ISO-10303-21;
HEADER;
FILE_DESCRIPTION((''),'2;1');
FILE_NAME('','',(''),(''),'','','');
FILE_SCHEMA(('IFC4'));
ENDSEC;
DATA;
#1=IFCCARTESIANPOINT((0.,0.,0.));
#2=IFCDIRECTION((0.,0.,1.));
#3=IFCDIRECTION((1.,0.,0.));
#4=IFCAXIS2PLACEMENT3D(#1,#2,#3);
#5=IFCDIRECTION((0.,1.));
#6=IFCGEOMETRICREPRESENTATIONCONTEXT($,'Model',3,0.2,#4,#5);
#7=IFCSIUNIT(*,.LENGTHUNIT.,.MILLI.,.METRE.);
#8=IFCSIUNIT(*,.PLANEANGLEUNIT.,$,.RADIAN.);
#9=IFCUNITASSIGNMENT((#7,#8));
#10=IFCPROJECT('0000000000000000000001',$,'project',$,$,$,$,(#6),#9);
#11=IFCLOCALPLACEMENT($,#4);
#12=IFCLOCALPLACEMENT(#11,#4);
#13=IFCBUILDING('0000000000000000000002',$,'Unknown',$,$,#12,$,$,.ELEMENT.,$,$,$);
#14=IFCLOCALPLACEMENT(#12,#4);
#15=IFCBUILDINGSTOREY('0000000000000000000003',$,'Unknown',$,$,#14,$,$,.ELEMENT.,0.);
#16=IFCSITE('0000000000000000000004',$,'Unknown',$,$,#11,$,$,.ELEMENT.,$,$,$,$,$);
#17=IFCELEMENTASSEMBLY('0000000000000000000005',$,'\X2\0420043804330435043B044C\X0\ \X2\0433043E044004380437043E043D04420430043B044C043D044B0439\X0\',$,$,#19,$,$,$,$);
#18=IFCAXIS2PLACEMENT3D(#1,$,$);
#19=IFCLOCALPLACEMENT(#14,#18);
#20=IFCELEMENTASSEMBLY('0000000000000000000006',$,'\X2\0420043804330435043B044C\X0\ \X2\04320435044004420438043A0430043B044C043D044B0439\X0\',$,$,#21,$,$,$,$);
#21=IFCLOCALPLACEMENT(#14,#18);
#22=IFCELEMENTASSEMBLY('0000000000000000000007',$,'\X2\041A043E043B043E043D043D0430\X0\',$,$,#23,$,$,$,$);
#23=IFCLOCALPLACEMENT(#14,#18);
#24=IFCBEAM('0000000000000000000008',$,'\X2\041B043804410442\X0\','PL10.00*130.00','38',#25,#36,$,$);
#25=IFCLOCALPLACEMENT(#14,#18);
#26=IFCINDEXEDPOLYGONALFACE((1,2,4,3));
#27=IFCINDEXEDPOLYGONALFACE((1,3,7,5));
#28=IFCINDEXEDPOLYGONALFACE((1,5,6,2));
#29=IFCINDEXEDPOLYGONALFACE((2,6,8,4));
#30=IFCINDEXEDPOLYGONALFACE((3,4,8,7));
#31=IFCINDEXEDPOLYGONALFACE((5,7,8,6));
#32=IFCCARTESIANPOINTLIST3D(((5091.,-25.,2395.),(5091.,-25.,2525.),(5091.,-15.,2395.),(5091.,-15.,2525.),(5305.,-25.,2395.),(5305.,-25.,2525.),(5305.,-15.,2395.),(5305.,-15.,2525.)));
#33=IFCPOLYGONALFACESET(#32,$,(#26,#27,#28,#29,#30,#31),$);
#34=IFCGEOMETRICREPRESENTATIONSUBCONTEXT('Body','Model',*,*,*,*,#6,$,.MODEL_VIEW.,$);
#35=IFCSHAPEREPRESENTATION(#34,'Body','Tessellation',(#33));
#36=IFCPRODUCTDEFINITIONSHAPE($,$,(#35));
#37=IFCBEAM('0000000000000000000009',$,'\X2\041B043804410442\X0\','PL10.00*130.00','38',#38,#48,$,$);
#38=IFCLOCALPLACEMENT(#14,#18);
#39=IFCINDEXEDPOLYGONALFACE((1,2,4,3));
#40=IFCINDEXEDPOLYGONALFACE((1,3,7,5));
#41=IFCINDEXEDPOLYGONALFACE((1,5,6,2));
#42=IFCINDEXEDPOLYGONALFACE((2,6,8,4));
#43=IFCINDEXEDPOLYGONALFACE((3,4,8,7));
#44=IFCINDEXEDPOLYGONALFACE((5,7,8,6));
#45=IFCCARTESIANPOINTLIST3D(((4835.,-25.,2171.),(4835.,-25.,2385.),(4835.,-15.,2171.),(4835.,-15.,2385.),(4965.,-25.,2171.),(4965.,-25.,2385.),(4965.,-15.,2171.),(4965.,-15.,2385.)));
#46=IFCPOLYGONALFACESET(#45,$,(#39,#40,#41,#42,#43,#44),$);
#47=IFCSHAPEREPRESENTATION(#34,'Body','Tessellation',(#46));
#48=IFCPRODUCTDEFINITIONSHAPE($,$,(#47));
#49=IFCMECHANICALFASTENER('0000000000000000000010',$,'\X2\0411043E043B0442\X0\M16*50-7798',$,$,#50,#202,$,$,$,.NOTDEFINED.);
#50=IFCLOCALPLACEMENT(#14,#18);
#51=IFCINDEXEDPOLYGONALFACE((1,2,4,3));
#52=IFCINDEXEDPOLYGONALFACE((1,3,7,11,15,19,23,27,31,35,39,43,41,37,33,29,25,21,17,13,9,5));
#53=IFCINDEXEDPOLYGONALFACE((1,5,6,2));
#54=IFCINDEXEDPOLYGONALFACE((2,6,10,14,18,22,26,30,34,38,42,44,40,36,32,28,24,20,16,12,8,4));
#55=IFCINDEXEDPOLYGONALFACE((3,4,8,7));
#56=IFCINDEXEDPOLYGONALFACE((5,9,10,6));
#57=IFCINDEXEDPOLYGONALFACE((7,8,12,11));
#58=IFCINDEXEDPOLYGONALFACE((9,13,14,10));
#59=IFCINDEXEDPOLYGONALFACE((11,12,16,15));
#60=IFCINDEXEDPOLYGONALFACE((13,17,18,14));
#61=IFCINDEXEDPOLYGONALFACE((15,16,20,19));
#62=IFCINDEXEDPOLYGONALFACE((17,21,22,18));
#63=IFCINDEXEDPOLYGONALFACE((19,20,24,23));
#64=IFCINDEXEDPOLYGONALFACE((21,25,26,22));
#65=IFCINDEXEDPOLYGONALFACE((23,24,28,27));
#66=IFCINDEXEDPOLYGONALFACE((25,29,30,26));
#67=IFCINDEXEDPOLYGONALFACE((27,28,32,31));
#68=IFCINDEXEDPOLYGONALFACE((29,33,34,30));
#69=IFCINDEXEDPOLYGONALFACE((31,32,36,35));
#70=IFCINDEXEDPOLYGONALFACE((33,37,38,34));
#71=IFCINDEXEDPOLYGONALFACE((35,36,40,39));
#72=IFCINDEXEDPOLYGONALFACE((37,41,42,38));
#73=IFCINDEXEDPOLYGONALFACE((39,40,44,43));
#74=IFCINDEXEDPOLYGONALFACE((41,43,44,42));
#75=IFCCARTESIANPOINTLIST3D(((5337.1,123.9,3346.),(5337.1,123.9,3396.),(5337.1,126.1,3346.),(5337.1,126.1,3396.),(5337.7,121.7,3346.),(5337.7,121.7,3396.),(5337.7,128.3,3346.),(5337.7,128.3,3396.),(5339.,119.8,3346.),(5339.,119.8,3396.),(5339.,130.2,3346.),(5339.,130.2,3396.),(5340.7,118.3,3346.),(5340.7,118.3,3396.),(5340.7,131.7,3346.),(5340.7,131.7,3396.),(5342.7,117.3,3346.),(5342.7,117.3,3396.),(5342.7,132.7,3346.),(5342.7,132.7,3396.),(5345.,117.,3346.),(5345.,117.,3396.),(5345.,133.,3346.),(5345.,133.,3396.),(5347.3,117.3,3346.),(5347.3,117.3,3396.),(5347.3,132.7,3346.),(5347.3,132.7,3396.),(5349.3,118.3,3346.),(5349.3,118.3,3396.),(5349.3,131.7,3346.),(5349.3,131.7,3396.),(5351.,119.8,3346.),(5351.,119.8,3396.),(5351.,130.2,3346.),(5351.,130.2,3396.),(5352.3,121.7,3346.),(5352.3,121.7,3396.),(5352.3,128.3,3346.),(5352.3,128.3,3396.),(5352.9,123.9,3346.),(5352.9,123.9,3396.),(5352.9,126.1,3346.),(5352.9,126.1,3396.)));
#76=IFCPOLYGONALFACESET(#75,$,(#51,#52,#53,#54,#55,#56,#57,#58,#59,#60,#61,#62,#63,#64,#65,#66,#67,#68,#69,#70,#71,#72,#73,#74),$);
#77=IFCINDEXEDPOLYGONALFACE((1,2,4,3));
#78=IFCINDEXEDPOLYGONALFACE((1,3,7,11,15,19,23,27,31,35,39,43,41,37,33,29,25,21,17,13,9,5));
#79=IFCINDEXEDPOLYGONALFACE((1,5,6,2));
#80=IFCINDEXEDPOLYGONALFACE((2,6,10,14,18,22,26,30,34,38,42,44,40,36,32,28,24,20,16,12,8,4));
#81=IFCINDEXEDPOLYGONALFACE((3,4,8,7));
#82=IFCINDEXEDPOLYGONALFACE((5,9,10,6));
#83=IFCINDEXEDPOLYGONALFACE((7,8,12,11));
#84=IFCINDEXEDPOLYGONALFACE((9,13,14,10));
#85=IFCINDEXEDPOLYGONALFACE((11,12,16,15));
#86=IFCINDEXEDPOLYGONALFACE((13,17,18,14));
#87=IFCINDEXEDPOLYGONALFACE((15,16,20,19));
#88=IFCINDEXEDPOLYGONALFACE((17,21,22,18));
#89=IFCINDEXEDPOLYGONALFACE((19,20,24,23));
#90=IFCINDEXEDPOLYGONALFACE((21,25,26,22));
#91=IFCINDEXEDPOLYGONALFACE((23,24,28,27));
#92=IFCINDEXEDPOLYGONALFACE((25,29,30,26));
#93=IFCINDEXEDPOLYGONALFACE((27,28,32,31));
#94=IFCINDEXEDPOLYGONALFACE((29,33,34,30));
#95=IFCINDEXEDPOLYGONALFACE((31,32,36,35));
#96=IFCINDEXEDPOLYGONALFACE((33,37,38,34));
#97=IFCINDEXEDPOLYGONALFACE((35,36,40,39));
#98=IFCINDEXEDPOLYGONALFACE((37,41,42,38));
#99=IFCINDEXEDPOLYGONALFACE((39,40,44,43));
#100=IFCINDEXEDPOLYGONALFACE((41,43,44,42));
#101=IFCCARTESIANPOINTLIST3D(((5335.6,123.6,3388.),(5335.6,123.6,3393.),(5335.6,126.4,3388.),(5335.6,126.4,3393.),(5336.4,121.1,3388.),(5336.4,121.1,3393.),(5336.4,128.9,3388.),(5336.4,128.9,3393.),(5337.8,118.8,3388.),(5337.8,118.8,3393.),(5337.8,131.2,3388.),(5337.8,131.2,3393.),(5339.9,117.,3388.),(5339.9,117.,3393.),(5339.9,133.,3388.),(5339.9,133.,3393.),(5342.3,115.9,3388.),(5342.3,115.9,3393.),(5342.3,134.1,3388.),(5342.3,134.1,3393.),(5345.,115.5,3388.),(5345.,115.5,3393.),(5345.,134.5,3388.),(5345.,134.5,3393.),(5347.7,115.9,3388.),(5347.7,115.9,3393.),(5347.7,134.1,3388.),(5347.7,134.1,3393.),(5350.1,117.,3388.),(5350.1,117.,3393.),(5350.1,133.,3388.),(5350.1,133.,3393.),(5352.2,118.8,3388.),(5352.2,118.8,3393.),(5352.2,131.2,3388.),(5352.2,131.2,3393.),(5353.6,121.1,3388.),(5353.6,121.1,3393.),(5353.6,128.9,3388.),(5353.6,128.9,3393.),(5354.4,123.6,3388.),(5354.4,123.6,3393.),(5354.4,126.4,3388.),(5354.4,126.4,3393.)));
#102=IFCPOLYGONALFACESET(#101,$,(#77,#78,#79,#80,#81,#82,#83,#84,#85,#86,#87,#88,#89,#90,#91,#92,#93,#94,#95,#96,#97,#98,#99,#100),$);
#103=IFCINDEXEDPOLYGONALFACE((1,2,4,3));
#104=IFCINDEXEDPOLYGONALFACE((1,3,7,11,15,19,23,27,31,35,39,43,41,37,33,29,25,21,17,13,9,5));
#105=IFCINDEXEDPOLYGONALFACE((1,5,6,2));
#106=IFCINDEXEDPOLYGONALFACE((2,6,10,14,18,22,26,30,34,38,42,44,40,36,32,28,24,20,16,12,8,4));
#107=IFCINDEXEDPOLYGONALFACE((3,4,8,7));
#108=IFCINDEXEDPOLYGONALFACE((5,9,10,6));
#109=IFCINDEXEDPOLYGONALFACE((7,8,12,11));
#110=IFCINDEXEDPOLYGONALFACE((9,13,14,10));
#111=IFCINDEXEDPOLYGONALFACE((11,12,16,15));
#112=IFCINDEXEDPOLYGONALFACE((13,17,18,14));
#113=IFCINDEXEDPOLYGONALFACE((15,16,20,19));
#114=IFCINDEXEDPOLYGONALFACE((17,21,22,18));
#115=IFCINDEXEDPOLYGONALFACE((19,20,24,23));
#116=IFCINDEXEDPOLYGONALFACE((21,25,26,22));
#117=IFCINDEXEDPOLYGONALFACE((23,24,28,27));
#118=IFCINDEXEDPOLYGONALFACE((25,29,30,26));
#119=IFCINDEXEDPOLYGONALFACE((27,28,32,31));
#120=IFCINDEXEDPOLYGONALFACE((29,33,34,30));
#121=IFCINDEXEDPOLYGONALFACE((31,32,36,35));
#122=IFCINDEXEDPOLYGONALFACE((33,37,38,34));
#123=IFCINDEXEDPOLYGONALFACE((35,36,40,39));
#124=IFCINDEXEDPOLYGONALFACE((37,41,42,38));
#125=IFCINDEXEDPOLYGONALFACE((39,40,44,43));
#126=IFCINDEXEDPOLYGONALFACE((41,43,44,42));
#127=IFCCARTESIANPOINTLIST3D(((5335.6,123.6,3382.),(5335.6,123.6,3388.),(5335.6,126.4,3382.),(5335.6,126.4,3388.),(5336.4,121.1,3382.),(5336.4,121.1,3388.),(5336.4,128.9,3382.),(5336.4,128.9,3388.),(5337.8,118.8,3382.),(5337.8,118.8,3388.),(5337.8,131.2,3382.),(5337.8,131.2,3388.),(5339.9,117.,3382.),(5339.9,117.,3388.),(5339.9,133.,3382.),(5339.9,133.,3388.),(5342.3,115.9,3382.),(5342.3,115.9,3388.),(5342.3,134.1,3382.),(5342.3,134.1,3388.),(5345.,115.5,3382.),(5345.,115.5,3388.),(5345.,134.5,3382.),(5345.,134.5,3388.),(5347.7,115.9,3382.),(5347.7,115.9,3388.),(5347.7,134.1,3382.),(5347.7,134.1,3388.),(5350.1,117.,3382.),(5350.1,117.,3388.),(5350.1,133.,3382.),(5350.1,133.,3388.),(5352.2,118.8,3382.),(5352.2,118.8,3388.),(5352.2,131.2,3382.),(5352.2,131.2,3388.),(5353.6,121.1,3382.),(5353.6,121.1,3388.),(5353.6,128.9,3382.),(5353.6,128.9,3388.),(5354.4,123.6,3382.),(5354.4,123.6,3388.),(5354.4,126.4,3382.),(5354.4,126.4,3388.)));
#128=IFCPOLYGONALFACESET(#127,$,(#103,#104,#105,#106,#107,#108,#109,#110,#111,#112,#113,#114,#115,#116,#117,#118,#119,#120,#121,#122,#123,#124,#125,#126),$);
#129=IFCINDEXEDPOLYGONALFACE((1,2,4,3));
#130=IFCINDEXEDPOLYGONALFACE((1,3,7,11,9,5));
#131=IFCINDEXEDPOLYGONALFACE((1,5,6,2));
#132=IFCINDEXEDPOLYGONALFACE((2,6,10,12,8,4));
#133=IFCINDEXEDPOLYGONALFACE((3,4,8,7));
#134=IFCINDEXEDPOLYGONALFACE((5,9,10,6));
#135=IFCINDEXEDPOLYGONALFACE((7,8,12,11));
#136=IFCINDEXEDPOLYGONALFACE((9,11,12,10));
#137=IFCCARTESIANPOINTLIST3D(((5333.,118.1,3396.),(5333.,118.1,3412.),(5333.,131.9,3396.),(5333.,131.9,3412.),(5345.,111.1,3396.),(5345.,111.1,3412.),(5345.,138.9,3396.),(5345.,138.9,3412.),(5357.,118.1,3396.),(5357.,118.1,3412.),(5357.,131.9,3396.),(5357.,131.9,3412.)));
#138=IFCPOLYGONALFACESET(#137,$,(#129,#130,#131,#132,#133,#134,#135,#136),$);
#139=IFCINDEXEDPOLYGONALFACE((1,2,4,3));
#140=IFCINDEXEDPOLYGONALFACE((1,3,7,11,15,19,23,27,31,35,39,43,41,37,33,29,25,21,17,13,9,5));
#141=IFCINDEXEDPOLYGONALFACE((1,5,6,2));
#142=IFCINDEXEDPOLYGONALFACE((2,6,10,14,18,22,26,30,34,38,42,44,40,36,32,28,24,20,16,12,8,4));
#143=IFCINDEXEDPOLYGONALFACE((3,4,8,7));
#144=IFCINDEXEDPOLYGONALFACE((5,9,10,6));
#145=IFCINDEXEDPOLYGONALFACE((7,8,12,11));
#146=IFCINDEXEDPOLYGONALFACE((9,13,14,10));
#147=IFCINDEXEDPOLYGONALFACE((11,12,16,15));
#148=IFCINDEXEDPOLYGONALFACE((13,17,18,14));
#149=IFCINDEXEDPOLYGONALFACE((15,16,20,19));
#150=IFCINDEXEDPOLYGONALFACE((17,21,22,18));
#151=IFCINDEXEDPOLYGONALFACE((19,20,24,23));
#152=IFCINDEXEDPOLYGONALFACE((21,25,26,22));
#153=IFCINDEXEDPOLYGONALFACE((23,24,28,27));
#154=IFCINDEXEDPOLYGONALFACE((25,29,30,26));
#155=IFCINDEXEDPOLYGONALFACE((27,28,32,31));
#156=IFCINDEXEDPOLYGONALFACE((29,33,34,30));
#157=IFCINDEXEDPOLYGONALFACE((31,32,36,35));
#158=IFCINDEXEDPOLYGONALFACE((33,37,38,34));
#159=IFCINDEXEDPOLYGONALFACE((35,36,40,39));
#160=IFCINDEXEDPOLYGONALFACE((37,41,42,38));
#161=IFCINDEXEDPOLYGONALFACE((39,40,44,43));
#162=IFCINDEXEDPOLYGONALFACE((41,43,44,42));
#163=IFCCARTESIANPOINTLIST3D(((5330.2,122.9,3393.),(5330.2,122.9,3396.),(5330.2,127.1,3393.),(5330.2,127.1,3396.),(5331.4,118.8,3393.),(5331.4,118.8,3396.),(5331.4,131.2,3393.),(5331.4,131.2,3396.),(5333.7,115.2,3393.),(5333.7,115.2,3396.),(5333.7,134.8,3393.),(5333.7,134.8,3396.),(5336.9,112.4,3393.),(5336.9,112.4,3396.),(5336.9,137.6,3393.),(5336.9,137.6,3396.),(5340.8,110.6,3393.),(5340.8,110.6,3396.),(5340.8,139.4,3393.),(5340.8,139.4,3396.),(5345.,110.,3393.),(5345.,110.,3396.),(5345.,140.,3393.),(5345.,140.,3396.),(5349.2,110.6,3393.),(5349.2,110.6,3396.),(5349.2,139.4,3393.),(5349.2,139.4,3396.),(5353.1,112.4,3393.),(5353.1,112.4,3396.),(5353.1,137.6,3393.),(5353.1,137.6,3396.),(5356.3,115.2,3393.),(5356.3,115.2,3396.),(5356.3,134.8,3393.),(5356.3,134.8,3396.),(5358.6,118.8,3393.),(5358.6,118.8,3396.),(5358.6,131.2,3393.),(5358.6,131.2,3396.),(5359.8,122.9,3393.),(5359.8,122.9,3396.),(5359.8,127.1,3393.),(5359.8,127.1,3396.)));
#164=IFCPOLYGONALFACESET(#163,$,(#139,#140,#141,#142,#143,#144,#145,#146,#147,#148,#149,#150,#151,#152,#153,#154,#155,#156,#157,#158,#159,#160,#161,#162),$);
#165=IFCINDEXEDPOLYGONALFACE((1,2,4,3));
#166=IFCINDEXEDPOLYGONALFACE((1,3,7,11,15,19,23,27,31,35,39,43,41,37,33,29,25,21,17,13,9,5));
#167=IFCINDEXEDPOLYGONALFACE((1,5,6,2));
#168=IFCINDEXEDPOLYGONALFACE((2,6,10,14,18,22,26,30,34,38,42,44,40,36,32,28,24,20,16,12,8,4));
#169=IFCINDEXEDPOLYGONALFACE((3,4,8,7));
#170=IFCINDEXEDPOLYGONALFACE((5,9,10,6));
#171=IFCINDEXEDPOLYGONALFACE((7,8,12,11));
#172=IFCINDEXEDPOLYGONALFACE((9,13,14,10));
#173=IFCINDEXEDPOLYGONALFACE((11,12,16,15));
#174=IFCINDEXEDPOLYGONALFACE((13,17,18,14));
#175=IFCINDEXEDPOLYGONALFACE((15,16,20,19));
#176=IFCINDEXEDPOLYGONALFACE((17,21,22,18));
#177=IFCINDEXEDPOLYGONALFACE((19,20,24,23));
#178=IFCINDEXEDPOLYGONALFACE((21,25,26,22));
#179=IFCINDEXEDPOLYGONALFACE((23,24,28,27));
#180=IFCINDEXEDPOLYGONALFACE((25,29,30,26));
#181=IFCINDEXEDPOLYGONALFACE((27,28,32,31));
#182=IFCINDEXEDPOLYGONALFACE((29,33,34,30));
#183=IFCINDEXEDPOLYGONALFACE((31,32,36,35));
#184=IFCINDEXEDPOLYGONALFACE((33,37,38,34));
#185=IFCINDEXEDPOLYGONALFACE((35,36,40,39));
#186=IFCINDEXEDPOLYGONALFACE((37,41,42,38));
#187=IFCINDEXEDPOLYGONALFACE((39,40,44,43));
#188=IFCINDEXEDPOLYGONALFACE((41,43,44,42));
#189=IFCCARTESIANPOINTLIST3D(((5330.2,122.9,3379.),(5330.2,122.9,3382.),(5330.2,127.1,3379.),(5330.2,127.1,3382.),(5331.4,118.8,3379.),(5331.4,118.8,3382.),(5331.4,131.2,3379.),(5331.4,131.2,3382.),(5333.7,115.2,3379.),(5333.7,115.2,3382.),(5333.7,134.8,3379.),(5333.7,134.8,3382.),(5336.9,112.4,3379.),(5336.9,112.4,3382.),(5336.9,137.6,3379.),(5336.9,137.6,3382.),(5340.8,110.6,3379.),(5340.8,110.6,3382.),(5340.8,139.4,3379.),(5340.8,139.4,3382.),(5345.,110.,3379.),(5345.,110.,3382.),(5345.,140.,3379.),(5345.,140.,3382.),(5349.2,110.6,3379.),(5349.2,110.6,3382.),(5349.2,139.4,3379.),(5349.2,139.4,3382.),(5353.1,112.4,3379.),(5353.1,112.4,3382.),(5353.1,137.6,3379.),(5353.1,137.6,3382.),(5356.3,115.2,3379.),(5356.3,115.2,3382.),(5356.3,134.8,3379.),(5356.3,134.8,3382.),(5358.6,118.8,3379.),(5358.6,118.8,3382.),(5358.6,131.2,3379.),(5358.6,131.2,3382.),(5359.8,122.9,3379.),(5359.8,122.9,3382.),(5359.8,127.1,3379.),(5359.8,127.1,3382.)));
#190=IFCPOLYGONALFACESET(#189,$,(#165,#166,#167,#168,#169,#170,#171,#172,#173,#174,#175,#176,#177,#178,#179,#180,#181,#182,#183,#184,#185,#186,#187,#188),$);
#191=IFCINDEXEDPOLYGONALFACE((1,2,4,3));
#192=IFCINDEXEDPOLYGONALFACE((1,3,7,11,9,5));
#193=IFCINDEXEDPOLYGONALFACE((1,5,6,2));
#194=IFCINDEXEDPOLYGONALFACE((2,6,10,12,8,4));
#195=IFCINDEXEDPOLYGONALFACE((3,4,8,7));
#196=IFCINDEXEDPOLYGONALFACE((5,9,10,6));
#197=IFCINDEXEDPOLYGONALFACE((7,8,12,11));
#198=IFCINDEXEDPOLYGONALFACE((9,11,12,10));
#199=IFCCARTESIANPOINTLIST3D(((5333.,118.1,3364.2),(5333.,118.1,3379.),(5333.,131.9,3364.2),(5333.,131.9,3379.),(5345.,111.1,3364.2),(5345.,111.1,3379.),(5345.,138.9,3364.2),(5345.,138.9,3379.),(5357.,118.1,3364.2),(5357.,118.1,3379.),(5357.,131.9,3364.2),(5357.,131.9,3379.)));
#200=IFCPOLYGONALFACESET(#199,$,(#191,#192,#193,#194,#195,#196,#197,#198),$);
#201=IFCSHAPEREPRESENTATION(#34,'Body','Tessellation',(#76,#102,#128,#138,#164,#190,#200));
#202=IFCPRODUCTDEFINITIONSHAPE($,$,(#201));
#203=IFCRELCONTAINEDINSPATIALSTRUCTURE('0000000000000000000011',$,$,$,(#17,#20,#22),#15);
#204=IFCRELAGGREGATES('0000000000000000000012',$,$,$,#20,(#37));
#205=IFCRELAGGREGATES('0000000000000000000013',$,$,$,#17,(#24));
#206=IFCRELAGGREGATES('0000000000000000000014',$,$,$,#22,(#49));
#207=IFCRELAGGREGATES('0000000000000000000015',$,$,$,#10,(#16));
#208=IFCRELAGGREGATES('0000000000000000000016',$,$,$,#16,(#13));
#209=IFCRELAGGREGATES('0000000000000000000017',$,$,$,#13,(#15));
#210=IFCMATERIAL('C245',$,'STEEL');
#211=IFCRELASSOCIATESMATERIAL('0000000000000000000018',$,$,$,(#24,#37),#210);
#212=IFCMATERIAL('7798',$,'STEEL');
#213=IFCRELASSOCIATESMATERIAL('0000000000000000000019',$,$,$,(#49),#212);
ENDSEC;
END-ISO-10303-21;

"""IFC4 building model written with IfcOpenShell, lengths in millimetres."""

from ifc_helpers import new_model, si_unit, direction, frame, origin_with_axes, place, context, subcontext, project, spatial, line, arc, indexed_curve, outline, extrude, source, transform, mapped, material, element, aggregate, save


model = new_model("IFC4")

# Units and contexts
model_context = context("Model", 3, precision=0.2, world=origin_with_axes(), true_north=direction((0.0, 1.0)))
body_context = subcontext(model_context, "Body", "Model", "MODEL_VIEW")
ifc_project = project(units=[si_unit("LENGTHUNIT", "METRE", prefix="MILLI"), si_unit("PLANEANGLEUNIT", "RADIAN")], contexts=[model_context])

# Site, building, storey
site_placement = place(None, origin_with_axes())
site = spatial("IfcSite", under=ifc_project, at=site_placement, Name="Unknown", CompositionType="ELEMENT")
building_placement = place(site_placement, origin_with_axes())
building = spatial("IfcBuilding", under=site, at=building_placement, Name="Unknown", CompositionType="ELEMENT")
storey_placement = place(building_placement, origin_with_axes())
storey = spatial("IfcBuildingStorey", under=building, at=storey_placement, Name="Unknown", CompositionType="ELEMENT", Elevation=0.0)

# Element assembly
assembly_1_placement = place(storey_placement, frame((0.0, -20.0, 2460.0), z_axis=(0.0, -1.0, 0.0), x_axis=(1.0, 0.0, 0.0)))
assembly_1 = element("IfcElementAssembly", 1, at=assembly_1_placement, inside=storey, Name="Ригель горизонтальный")
ifc_material_1 = material(Name="C245", Category="STEEL")

# Element assembly
assembly_2_placement = place(storey_placement, frame((4900.0, -20.0, 2400.0), z_axis=(0.0, -1.0, 0.0), x_axis=(0.0, 0.0, -1.0)))
assembly_2 = element("IfcElementAssembly", 2, at=assembly_2_placement, inside=storey, Name="Ригель вертикальный")

# Element assembly
assembly_3_placement = place(storey_placement, frame((5400.0, 0.0, -40.0), z_axis=(-1.0, 0.0, 0.0), x_axis=(0.0, 0.0, 1.0)))
assembly_3 = element("IfcElementAssembly", 3, at=assembly_3_placement, inside=storey, Name="Колонна")

# Beams
beam_1_placement = place(assembly_1_placement, frame((5305.0, 0.0, 0.0), z_axis=(0.0, 0.0, 1.0), x_axis=(-1.0, 0.0, 0.0)))
beam_1 = element("IfcBeam", 4, at=beam_1_placement, material=ifc_material_1, Name="Лист", Description="PL10.00*130.00", ObjectType="38", context=body_context, shape_type="SolidModel", body=[
    extrude(outline(indexed_curve([(-5.0, -65.0), (5.0, -65.0), (5.0, 65.0), (-5.0, 65.0)], segments=[line(1, 2, 3, 4, 1)])), frame((0.0, 0.0, 0.0), z_axis=(-1.0, 0.0, 0.0), x_axis=(0.0, 0.0, 1.0)), (0.0, 0.0, -1.0), 214.0),
])
beam_2_placement = place(assembly_2_placement, frame((15.0, 0.0, 0.0), z_axis=(0.0, 0.0, 1.0), x_axis=(1.0, 0.0, 0.0)))
beam_2 = element("IfcBeam", 5, at=beam_2_placement, material=ifc_material_1, Name="Лист", Description="PL10.00*130.00", ObjectType="38", context=body_context, shape_type="SolidModel", body=[
    extrude(outline(indexed_curve([(-5.0, -65.0), (5.0, -65.0), (5.0, 65.0), (-5.0, 65.0)], segments=[line(1, 2, 3, 4, 1)])), frame((0.0, 0.0, 0.0), z_axis=(-1.0, 0.0, 0.0), x_axis=(0.0, 0.0, 1.0)), (0.0, 0.0, -1.0), 214.0),
])
aggregate(assembly_2, [beam_2])

# Mechanical fastener
ifc_material_2 = material(Name="7798", Category="STEEL")
aggregate(assembly_1, [beam_1])
shared_shape_1 = source(origin_with_axes(), body_context, "Body", "SweptSolid", [
    extrude(outline(indexed_curve([(8.0, 0.0), (0.0, 8.0), (-8.0, 0.0), (0.0, -8.0)], segments=[arc(1, 2, 3), arc(3, 4, 1)])), frame((0.0, 0.0, 8.0), z_axis=(0.0, 0.0, -1.0), x_axis=(0.0, 1.0, 0.0)), (0.0, 0.0, 1.0), 50.0),
    extrude(outline(indexed_curve([(9.5, 0.0), (0.0, 9.5), (-9.5, 0.0), (0.0, -9.5)], segments=[arc(1, 2, 3), arc(3, 4, 1)])), frame((0.0, 0.0, 5.0), z_axis=(0.0, 0.0, -1.0), x_axis=(0.0, 1.0, 0.0)), (0.0, 0.0, 1.0), 5.0),
    extrude(outline(indexed_curve([(9.5, 0.0), (0.0, 9.5), (-9.5, 0.0), (0.0, -9.5)], segments=[arc(1, 2, 3), arc(3, 4, 1)])), frame((0.0, 0.0, 0.0), z_axis=(0.0, 0.0, -1.0), x_axis=(0.0, 1.0, 0.0)), (0.0, 0.0, 1.0), 6.0),
    extrude(outline(indexed_curve([(13.9, 0.0), (6.9, 12.0), (-6.9, 12.0), (-13.9, 0.0), (-6.9, -12.0), (6.9, -12.0)], segments=[line(1, 2, 3, 4, 5, 6, 1)])), frame((0.0, 0.0, 24.0), z_axis=(0.0, 0.0, -1.0), x_axis=(0.0, 1.0, 0.0)), (0.0, 0.0, 1.0), 16.0),
    extrude(outline(indexed_curve([(15.0, 0.0), (0.0, 15.0), (-15.0, 0.0), (0.0, -15.0)], segments=[arc(1, 2, 3), arc(3, 4, 1)])), frame((0.0, 0.0, 8.0), z_axis=(0.0, 0.0, -1.0), x_axis=(0.0, 1.0, 0.0)), (0.0, 0.0, 1.0), 3.0),
    extrude(outline(indexed_curve([(15.0, 0.0), (0.0, 15.0), (-15.0, 0.0), (0.0, -15.0)], segments=[arc(1, 2, 3), arc(3, 4, 1)])), frame((0.0, 0.0, -6.0), z_axis=(0.0, 0.0, -1.0), x_axis=(0.0, 1.0, 0.0)), (0.0, 0.0, 1.0), 3.0),
    extrude(outline(indexed_curve([(13.9, 0.0), (6.9, 12.0), (-6.9, 12.0), (-13.9, 0.0), (-6.9, -12.0), (6.9, -12.0)], segments=[line(1, 2, 3, 4, 5, 6, 1)])), frame((0.0, 0.0, -9.0), z_axis=(0.0, 0.0, -1.0), x_axis=(0.0, 1.0, 0.0)), (0.0, 0.0, 1.0), 14.8),
])
mechanical_fastener_1_placement = place(assembly_3_placement, frame((3428.0, 125.0, 55.0), z_axis=(1.0, 0.0, 0.0), x_axis=(0.0, 0.0, -1.0)))
mechanical_fastener_1 = element("IfcMechanicalFastener", 6, at=mechanical_fastener_1_placement, material=ifc_material_2, Name="БолтM16*50-7798", PredefinedType="NOTDEFINED", context=body_context, shape_type="MappedRepresentation", body=[
    mapped(shared_shape_1, transform((0.0, 0.0, 0.0))),
])
aggregate(assembly_3, [mechanical_fastener_1])

save(model, "model.ifc")
